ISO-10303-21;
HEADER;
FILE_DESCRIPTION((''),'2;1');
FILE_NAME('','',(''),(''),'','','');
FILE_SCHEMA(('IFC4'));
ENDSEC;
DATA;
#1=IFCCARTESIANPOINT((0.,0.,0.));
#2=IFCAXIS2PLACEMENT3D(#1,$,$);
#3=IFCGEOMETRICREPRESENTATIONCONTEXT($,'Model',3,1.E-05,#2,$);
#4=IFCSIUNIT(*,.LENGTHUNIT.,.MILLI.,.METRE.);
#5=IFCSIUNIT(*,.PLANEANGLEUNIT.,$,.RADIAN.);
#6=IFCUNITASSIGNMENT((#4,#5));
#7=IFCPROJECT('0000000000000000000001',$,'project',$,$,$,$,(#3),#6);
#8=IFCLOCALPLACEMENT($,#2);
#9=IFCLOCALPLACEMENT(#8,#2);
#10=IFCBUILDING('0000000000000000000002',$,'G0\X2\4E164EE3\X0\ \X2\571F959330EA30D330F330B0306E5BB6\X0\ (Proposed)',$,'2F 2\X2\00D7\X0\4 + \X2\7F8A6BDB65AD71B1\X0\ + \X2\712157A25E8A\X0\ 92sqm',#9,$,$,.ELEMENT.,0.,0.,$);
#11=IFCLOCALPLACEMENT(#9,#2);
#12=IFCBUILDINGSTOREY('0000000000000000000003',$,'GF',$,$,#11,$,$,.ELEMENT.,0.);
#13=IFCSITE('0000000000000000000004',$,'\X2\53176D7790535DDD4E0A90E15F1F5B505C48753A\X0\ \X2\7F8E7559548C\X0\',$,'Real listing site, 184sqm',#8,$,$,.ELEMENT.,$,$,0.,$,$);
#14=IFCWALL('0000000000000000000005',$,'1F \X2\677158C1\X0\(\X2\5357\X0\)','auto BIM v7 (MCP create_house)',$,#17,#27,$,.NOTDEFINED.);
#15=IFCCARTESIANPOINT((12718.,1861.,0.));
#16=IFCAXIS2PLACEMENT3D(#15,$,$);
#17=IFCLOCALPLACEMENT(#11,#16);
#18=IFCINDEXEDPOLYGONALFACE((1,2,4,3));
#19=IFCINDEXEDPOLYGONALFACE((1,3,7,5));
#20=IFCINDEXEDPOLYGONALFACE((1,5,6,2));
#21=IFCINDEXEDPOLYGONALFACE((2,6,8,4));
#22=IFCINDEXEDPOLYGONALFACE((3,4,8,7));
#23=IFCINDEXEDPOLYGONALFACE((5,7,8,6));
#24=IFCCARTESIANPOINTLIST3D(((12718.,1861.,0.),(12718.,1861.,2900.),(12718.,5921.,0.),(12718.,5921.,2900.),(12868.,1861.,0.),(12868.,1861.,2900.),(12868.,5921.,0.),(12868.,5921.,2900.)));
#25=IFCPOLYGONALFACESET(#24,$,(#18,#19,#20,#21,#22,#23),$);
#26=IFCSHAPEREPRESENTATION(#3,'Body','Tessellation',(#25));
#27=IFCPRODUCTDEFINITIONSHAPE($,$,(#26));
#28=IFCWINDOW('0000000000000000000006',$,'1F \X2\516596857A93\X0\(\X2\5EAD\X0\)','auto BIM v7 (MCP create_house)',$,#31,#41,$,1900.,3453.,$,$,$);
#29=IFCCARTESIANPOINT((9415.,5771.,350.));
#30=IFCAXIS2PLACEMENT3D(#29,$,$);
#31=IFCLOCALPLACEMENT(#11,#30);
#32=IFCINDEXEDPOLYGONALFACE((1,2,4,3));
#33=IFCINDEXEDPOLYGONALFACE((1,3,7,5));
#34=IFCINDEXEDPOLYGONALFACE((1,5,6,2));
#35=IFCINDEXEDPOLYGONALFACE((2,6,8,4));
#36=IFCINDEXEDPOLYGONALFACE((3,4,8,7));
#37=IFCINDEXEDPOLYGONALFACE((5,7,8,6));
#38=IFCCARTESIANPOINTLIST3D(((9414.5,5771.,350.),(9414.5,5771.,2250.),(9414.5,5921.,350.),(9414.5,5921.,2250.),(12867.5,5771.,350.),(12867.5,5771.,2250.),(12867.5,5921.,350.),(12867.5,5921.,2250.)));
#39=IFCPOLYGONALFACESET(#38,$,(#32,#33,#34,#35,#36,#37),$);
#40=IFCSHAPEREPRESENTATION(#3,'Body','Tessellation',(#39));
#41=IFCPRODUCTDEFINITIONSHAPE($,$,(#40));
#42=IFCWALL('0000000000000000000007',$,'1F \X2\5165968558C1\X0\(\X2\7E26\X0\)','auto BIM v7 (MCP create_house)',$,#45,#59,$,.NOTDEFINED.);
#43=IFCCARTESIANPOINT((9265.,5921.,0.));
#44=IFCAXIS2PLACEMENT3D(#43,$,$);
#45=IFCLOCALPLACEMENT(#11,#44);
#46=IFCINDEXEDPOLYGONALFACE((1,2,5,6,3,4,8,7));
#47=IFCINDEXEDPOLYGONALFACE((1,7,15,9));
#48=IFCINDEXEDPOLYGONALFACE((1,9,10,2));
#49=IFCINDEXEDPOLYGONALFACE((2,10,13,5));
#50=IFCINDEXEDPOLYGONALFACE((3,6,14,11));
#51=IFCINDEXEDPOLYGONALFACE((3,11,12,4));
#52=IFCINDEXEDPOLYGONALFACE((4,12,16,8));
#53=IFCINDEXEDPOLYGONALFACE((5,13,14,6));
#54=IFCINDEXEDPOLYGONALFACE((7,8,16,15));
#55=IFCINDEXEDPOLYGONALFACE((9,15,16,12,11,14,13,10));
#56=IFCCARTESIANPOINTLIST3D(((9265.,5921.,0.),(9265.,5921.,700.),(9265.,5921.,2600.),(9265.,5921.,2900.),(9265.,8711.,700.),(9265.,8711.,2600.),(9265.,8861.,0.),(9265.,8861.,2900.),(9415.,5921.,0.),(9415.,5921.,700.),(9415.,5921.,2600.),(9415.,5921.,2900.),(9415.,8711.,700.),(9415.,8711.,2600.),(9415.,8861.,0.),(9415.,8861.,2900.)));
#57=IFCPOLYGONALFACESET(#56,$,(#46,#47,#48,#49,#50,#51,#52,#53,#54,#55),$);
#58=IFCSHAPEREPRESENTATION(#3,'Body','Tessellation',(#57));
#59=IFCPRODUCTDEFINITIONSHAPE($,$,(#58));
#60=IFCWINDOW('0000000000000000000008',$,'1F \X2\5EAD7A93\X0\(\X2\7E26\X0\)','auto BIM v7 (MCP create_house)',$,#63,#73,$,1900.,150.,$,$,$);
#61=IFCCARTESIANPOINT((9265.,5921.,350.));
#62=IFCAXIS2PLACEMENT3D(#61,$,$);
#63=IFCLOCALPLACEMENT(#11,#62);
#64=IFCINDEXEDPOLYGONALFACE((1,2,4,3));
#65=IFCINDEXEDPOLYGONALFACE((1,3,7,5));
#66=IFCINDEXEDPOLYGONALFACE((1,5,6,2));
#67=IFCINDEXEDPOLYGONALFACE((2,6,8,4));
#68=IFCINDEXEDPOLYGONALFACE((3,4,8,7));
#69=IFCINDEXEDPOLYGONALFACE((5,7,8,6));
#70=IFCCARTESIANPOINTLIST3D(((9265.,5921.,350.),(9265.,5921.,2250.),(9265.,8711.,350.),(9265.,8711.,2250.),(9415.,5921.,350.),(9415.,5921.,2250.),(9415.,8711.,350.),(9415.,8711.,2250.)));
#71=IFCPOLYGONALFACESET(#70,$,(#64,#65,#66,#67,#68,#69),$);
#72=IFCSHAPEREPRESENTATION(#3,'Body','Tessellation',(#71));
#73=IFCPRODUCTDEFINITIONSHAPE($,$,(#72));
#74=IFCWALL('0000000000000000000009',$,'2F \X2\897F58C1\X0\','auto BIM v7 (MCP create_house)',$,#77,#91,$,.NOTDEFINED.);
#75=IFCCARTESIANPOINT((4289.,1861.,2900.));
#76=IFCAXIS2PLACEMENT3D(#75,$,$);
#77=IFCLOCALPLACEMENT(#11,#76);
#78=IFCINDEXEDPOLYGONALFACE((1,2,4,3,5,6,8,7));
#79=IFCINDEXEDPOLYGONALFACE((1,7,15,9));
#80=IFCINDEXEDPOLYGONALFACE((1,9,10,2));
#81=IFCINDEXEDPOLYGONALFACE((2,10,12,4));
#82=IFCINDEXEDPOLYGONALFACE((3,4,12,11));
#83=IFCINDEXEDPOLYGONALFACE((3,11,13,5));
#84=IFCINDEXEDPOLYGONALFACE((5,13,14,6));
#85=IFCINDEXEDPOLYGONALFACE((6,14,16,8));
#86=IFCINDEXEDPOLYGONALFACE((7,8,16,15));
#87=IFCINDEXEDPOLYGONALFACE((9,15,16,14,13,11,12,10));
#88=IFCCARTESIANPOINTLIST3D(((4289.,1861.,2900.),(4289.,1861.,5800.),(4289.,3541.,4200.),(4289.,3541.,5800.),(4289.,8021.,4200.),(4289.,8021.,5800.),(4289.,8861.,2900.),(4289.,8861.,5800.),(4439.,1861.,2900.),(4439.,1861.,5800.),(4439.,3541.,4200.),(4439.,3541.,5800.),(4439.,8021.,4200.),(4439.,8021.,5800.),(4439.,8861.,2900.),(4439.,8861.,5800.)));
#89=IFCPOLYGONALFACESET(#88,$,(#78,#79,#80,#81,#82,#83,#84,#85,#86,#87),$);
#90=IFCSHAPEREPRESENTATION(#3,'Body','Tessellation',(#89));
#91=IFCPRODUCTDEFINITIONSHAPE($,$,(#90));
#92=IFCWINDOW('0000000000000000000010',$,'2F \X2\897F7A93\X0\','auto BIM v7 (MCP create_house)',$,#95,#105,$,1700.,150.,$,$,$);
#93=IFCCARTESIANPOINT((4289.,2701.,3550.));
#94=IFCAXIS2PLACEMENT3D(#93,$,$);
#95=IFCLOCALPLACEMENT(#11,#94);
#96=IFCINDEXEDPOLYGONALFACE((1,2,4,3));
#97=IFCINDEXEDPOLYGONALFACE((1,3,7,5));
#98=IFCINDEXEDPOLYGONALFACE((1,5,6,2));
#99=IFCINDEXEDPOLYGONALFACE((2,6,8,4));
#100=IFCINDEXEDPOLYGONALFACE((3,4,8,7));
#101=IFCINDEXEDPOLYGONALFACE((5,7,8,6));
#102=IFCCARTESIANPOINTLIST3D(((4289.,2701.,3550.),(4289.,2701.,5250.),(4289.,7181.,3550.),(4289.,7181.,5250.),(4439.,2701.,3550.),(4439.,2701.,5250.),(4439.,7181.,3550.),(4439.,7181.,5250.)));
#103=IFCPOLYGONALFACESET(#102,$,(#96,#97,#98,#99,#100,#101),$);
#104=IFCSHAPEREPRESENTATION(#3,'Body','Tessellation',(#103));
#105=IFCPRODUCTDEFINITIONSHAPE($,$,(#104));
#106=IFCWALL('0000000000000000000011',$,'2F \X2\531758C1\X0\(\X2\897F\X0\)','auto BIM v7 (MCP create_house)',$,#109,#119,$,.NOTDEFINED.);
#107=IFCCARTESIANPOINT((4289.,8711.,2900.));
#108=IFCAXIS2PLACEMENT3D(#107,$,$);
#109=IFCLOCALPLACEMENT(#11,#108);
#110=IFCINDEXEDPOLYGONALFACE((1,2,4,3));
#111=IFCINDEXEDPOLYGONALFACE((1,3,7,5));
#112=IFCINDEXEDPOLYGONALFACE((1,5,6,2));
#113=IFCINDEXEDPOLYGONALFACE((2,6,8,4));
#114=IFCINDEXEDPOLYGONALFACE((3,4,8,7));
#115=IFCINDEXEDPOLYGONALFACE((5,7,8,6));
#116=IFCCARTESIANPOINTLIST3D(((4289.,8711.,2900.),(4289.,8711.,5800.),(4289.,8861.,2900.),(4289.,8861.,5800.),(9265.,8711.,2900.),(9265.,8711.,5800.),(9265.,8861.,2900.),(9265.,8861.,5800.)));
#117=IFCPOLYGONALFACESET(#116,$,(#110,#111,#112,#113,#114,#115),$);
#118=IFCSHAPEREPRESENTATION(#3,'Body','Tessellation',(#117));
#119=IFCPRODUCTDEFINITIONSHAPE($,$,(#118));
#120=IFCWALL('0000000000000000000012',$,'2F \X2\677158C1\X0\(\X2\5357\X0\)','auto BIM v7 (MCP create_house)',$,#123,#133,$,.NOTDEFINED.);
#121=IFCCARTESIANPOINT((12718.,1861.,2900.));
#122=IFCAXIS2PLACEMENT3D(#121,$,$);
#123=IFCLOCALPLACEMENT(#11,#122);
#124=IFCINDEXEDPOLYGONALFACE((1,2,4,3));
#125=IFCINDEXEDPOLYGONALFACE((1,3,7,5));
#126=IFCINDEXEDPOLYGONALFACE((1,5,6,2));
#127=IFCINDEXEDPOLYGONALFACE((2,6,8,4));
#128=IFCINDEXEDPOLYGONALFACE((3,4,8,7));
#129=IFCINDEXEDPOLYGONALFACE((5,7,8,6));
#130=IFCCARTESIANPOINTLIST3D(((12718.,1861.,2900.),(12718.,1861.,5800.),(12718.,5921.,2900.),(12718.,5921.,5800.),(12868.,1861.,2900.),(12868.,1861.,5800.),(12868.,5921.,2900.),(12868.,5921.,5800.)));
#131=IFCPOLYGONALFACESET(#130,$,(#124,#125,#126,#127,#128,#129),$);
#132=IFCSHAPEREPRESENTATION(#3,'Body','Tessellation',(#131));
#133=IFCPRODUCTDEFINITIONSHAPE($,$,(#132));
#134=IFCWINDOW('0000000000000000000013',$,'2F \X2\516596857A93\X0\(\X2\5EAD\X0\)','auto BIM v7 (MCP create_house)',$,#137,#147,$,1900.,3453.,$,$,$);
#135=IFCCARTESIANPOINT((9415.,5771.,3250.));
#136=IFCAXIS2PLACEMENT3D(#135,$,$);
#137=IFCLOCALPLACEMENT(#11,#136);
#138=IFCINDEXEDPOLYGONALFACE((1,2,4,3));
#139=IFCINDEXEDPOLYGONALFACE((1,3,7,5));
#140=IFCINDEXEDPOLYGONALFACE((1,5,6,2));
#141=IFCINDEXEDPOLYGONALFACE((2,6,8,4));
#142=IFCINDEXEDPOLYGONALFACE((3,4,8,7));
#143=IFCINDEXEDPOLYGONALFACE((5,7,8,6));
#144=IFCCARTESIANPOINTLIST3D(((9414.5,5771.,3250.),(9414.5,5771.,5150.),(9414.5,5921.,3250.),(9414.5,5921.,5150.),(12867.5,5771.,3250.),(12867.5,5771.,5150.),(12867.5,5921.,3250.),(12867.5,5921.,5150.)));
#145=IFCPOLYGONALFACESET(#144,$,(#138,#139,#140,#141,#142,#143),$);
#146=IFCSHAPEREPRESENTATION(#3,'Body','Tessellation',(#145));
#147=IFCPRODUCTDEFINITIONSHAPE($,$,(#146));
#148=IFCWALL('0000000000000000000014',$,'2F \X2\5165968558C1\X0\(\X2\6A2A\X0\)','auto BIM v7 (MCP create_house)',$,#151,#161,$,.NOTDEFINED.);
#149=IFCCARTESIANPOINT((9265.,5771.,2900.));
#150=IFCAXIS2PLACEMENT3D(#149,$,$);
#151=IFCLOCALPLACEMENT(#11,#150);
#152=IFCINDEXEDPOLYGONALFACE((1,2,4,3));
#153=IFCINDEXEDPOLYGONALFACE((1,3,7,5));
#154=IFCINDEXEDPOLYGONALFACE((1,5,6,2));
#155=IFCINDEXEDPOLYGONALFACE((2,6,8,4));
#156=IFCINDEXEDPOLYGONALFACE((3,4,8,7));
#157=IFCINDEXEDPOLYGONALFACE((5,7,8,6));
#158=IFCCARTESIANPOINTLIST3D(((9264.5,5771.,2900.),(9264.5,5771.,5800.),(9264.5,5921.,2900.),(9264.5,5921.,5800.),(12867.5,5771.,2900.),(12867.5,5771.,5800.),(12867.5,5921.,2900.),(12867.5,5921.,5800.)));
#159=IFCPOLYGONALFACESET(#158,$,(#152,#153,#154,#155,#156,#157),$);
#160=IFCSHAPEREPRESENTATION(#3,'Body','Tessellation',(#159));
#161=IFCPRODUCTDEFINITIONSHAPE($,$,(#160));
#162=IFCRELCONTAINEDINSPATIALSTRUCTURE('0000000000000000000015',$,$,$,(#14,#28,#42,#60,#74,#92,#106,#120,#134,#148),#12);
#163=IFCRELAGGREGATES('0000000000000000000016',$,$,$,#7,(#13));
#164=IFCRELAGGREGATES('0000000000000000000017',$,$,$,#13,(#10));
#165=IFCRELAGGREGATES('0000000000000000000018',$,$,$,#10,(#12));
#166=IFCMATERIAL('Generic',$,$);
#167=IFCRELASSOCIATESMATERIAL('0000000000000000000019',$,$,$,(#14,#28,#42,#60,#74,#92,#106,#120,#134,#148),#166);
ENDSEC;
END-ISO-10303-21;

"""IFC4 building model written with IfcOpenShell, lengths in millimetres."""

from ifc_helpers import new_model, si_unit, frame, frame_2d, origin, place, context, project, spatial, rectangle, extrude, material, element, fill, save


model = new_model("IFC4")

# Units and contexts
model_context = context("Model", 3, precision=1e-05, world=origin())
ifc_project = project(units=[si_unit("LENGTHUNIT", "METRE", prefix="MILLI"), si_unit("PLANEANGLEUNIT", "RADIAN")], contexts=[model_context])

# Site, building, storey
site_placement = place(None, origin())
site = spatial("IfcSite", under=ifc_project, at=site_placement, Name="北海道川上郡弟子屈町 美留和", ObjectType="Real listing site, 184sqm", CompositionType="ELEMENT", RefElevation=0.0)
building_placement = place(site_placement, origin())
building = spatial("IfcBuilding", under=site, at=building_placement, Name="G0世代 土間リビングの家 (Proposed)", ObjectType="2F 2×4 + 羊毛断熱 + 無垢床 92sqm", CompositionType="ELEMENT", ElevationOfRefHeight=0.0, ElevationOfTerrain=0.0)
storey_placement = place(building_placement, origin())
storey = spatial("IfcBuildingStorey", under=building, at=storey_placement, Name="GF", CompositionType="ELEMENT", Elevation=0.0)

# Shared definitions
ifc_material = material(Name="Generic")

# Wall, opening, window
wall_1_placement = place(storey_placement, frame((12718.0, 1861.0, 0.0)))
wall_1 = element("IfcWall", 1, at=wall_1_placement, inside=storey, material=ifc_material, Name="1F 東壁(南)", Description="auto BIM v7 (MCP create_house)", PredefinedType="NOTDEFINED", context=model_context, shape_type="SweptSolid", body=[
    extrude(rectangle(XDim=150.0, YDim=4060.0, at=frame_2d((75.0, 2030.0))), frame((12718.0, 1861.0, 0.0)), (0.0, 0.0, 1.0), 2900.0),
])
opening_1_placement = place(storey_placement, frame((9415.0, 5771.0, 350.0)))
opening_1 = element("IfcOpeningElement", 2, at=opening_1_placement, cuts=wall_1, PredefinedType="NOTDEFINED", context=model_context, shape_type="SweptSolid", body=[
    extrude(rectangle(XDim=3453.0, YDim=150.0, at=frame_2d((1726.0, 75.0))), frame((9415.0, 5771.0, 350.0)), (0.0, 0.0, 1.0), 1900.0),
])
window_1_placement = place(storey_placement, frame((9415.0, 5771.0, 350.0)))
window_1 = element("IfcWindow", 3, at=window_1_placement, inside=storey, material=ifc_material, Name="1F 入隅窓(庭)", Description="auto BIM v7 (MCP create_house)", OverallHeight=1900.0, OverallWidth=3453.0, context=model_context, shape_type="SweptSolid", body=[
    extrude(rectangle(XDim=3453.0, YDim=150.0, at=frame_2d((1726.0, 75.0))), frame((9415.0, 5771.0, 350.0)), (0.0, 0.0, 1.0), 1900.0),
])
fill(opening_1, window_1)

# Wall, opening, window
wall_2_placement = place(storey_placement, frame((9265.0, 5921.0, 0.0)))
wall_2 = element("IfcWall", 4, at=wall_2_placement, inside=storey, material=ifc_material, Name="1F 入隅壁(縦)", Description="auto BIM v7 (MCP create_house)", PredefinedType="NOTDEFINED", context=model_context, shape_type="SweptSolid", body=[
    extrude(rectangle(XDim=150.0, YDim=2940.0, at=frame_2d((75.0, 1470.0))), frame((9265.0, 5921.0, 0.0)), (0.0, 0.0, 1.0), 2900.0),
])
opening_2_placement = place(storey_placement, frame((9265.0, 5921.0, 350.0)))
opening_2 = element("IfcOpeningElement", 5, at=opening_2_placement, cuts=wall_2, PredefinedType="NOTDEFINED", context=model_context, shape_type="SweptSolid", body=[
    extrude(rectangle(XDim=150.0, YDim=2790.0, at=frame_2d((75.0, 1395.0))), frame((9265.0, 5921.0, 350.0)), (0.0, 0.0, 1.0), 1900.0),
])
window_2_placement = place(storey_placement, frame((9265.0, 5921.0, 350.0)))
window_2 = element("IfcWindow", 6, at=window_2_placement, inside=storey, material=ifc_material, Name="1F 庭窓(縦)", Description="auto BIM v7 (MCP create_house)", OverallHeight=1900.0, OverallWidth=150.0, context=model_context, shape_type="SweptSolid", body=[
    extrude(rectangle(XDim=150.0, YDim=2790.0, at=frame_2d((75.0, 1395.0))), frame((9265.0, 5921.0, 350.0)), (0.0, 0.0, 1.0), 1900.0),
])
fill(opening_2, window_2)

# Wall, opening, window
wall_3_placement = place(storey_placement, frame((4289.0, 1861.0, 2900.0)))
wall_3 = element("IfcWall", 7, at=wall_3_placement, inside=storey, material=ifc_material, Name="2F 西壁", Description="auto BIM v7 (MCP create_house)", PredefinedType="NOTDEFINED", context=model_context, shape_type="SweptSolid", body=[
    extrude(rectangle(XDim=150.0, YDim=7000.0, at=frame_2d((75.0, 3500.0))), frame((4289.0, 1861.0, 2900.0)), (0.0, 0.0, 1.0), 2900.0),
])
opening_3_placement = place(storey_placement, frame((4289.0, 2701.0, 3550.0)))
opening_3 = element("IfcOpeningElement", 8, at=opening_3_placement, cuts=wall_3, PredefinedType="NOTDEFINED", context=model_context, shape_type="SweptSolid", body=[
    extrude(rectangle(XDim=150.0, YDim=4480.0, at=frame_2d((75.0, 2240.0))), frame((4289.0, 2701.0, 3550.0)), (0.0, 0.0, 1.0), 1700.0),
])
window_3_placement = place(storey_placement, frame((4289.0, 2701.0, 3550.0)))
window_3 = element("IfcWindow", 9, at=window_3_placement, inside=storey, material=ifc_material, Name="2F 西窓", Description="auto BIM v7 (MCP create_house)", OverallHeight=1700.0, OverallWidth=150.0, context=model_context, shape_type="SweptSolid", body=[
    extrude(rectangle(XDim=150.0, YDim=4480.0, at=frame_2d((75.0, 2240.0))), frame((4289.0, 2701.0, 3550.0)), (0.0, 0.0, 1.0), 1700.0),
])
fill(opening_3, window_3)

# Wall
wall_4_placement = place(storey_placement, frame((4289.0, 8711.0, 2900.0)))
element("IfcWall", 10, at=wall_4_placement, inside=storey, material=ifc_material, Name="2F 北壁(西)", Description="auto BIM v7 (MCP create_house)", PredefinedType="NOTDEFINED", context=model_context, shape_type="SweptSolid", body=[
    extrude(rectangle(XDim=4976.0, YDim=150.0, at=frame_2d((2488.0, 75.0))), frame((4289.0, 8711.0, 2900.0)), (0.0, 0.0, 1.0), 2900.0),
])

# Wall, opening, window
wall_5_placement = place(storey_placement, frame((12718.0, 1861.0, 2900.0)))
wall_5 = element("IfcWall", 11, at=wall_5_placement, inside=storey, material=ifc_material, Name="2F 東壁(南)", Description="auto BIM v7 (MCP create_house)", PredefinedType="NOTDEFINED", context=model_context, shape_type="SweptSolid", body=[
    extrude(rectangle(XDim=150.0, YDim=4060.0, at=frame_2d((75.0, 2030.0))), frame((12718.0, 1861.0, 2900.0)), (0.0, 0.0, 1.0), 2900.0),
])
opening_4_placement = place(storey_placement, frame((9415.0, 5771.0, 3250.0)))
opening_4 = element("IfcOpeningElement", 12, at=opening_4_placement, cuts=wall_5, PredefinedType="NOTDEFINED", context=model_context, shape_type="SweptSolid", body=[
    extrude(rectangle(XDim=3453.0, YDim=150.0, at=frame_2d((1726.0, 75.0))), frame((9415.0, 5771.0, 3250.0)), (0.0, 0.0, 1.0), 1900.0),
])
window_4_placement = place(storey_placement, frame((9415.0, 5771.0, 3250.0)))
window_4 = element("IfcWindow", 13, at=window_4_placement, inside=storey, material=ifc_material, Name="2F 入隅窓(庭)", Description="auto BIM v7 (MCP create_house)", OverallHeight=1900.0, OverallWidth=3453.0, context=model_context, shape_type="SweptSolid", body=[
    extrude(rectangle(XDim=3453.0, YDim=150.0, at=frame_2d((1726.0, 75.0))), frame((9415.0, 5771.0, 3250.0)), (0.0, 0.0, 1.0), 1900.0),
])
fill(opening_4, window_4)

# Wall
wall_6_placement = place(storey_placement, frame((9265.0, 5771.0, 2900.0)))
element("IfcWall", 14, at=wall_6_placement, inside=storey, material=ifc_material, Name="2F 入隅壁(横)", Description="auto BIM v7 (MCP create_house)", PredefinedType="NOTDEFINED", context=model_context, shape_type="SweptSolid", body=[
    extrude(rectangle(XDim=3603.0, YDim=150.0, at=frame_2d((1801.0, 75.0))), frame((9265.0, 5771.0, 2900.0)), (0.0, 0.0, 1.0), 2900.0),
])

save(model, "model.ifc")
